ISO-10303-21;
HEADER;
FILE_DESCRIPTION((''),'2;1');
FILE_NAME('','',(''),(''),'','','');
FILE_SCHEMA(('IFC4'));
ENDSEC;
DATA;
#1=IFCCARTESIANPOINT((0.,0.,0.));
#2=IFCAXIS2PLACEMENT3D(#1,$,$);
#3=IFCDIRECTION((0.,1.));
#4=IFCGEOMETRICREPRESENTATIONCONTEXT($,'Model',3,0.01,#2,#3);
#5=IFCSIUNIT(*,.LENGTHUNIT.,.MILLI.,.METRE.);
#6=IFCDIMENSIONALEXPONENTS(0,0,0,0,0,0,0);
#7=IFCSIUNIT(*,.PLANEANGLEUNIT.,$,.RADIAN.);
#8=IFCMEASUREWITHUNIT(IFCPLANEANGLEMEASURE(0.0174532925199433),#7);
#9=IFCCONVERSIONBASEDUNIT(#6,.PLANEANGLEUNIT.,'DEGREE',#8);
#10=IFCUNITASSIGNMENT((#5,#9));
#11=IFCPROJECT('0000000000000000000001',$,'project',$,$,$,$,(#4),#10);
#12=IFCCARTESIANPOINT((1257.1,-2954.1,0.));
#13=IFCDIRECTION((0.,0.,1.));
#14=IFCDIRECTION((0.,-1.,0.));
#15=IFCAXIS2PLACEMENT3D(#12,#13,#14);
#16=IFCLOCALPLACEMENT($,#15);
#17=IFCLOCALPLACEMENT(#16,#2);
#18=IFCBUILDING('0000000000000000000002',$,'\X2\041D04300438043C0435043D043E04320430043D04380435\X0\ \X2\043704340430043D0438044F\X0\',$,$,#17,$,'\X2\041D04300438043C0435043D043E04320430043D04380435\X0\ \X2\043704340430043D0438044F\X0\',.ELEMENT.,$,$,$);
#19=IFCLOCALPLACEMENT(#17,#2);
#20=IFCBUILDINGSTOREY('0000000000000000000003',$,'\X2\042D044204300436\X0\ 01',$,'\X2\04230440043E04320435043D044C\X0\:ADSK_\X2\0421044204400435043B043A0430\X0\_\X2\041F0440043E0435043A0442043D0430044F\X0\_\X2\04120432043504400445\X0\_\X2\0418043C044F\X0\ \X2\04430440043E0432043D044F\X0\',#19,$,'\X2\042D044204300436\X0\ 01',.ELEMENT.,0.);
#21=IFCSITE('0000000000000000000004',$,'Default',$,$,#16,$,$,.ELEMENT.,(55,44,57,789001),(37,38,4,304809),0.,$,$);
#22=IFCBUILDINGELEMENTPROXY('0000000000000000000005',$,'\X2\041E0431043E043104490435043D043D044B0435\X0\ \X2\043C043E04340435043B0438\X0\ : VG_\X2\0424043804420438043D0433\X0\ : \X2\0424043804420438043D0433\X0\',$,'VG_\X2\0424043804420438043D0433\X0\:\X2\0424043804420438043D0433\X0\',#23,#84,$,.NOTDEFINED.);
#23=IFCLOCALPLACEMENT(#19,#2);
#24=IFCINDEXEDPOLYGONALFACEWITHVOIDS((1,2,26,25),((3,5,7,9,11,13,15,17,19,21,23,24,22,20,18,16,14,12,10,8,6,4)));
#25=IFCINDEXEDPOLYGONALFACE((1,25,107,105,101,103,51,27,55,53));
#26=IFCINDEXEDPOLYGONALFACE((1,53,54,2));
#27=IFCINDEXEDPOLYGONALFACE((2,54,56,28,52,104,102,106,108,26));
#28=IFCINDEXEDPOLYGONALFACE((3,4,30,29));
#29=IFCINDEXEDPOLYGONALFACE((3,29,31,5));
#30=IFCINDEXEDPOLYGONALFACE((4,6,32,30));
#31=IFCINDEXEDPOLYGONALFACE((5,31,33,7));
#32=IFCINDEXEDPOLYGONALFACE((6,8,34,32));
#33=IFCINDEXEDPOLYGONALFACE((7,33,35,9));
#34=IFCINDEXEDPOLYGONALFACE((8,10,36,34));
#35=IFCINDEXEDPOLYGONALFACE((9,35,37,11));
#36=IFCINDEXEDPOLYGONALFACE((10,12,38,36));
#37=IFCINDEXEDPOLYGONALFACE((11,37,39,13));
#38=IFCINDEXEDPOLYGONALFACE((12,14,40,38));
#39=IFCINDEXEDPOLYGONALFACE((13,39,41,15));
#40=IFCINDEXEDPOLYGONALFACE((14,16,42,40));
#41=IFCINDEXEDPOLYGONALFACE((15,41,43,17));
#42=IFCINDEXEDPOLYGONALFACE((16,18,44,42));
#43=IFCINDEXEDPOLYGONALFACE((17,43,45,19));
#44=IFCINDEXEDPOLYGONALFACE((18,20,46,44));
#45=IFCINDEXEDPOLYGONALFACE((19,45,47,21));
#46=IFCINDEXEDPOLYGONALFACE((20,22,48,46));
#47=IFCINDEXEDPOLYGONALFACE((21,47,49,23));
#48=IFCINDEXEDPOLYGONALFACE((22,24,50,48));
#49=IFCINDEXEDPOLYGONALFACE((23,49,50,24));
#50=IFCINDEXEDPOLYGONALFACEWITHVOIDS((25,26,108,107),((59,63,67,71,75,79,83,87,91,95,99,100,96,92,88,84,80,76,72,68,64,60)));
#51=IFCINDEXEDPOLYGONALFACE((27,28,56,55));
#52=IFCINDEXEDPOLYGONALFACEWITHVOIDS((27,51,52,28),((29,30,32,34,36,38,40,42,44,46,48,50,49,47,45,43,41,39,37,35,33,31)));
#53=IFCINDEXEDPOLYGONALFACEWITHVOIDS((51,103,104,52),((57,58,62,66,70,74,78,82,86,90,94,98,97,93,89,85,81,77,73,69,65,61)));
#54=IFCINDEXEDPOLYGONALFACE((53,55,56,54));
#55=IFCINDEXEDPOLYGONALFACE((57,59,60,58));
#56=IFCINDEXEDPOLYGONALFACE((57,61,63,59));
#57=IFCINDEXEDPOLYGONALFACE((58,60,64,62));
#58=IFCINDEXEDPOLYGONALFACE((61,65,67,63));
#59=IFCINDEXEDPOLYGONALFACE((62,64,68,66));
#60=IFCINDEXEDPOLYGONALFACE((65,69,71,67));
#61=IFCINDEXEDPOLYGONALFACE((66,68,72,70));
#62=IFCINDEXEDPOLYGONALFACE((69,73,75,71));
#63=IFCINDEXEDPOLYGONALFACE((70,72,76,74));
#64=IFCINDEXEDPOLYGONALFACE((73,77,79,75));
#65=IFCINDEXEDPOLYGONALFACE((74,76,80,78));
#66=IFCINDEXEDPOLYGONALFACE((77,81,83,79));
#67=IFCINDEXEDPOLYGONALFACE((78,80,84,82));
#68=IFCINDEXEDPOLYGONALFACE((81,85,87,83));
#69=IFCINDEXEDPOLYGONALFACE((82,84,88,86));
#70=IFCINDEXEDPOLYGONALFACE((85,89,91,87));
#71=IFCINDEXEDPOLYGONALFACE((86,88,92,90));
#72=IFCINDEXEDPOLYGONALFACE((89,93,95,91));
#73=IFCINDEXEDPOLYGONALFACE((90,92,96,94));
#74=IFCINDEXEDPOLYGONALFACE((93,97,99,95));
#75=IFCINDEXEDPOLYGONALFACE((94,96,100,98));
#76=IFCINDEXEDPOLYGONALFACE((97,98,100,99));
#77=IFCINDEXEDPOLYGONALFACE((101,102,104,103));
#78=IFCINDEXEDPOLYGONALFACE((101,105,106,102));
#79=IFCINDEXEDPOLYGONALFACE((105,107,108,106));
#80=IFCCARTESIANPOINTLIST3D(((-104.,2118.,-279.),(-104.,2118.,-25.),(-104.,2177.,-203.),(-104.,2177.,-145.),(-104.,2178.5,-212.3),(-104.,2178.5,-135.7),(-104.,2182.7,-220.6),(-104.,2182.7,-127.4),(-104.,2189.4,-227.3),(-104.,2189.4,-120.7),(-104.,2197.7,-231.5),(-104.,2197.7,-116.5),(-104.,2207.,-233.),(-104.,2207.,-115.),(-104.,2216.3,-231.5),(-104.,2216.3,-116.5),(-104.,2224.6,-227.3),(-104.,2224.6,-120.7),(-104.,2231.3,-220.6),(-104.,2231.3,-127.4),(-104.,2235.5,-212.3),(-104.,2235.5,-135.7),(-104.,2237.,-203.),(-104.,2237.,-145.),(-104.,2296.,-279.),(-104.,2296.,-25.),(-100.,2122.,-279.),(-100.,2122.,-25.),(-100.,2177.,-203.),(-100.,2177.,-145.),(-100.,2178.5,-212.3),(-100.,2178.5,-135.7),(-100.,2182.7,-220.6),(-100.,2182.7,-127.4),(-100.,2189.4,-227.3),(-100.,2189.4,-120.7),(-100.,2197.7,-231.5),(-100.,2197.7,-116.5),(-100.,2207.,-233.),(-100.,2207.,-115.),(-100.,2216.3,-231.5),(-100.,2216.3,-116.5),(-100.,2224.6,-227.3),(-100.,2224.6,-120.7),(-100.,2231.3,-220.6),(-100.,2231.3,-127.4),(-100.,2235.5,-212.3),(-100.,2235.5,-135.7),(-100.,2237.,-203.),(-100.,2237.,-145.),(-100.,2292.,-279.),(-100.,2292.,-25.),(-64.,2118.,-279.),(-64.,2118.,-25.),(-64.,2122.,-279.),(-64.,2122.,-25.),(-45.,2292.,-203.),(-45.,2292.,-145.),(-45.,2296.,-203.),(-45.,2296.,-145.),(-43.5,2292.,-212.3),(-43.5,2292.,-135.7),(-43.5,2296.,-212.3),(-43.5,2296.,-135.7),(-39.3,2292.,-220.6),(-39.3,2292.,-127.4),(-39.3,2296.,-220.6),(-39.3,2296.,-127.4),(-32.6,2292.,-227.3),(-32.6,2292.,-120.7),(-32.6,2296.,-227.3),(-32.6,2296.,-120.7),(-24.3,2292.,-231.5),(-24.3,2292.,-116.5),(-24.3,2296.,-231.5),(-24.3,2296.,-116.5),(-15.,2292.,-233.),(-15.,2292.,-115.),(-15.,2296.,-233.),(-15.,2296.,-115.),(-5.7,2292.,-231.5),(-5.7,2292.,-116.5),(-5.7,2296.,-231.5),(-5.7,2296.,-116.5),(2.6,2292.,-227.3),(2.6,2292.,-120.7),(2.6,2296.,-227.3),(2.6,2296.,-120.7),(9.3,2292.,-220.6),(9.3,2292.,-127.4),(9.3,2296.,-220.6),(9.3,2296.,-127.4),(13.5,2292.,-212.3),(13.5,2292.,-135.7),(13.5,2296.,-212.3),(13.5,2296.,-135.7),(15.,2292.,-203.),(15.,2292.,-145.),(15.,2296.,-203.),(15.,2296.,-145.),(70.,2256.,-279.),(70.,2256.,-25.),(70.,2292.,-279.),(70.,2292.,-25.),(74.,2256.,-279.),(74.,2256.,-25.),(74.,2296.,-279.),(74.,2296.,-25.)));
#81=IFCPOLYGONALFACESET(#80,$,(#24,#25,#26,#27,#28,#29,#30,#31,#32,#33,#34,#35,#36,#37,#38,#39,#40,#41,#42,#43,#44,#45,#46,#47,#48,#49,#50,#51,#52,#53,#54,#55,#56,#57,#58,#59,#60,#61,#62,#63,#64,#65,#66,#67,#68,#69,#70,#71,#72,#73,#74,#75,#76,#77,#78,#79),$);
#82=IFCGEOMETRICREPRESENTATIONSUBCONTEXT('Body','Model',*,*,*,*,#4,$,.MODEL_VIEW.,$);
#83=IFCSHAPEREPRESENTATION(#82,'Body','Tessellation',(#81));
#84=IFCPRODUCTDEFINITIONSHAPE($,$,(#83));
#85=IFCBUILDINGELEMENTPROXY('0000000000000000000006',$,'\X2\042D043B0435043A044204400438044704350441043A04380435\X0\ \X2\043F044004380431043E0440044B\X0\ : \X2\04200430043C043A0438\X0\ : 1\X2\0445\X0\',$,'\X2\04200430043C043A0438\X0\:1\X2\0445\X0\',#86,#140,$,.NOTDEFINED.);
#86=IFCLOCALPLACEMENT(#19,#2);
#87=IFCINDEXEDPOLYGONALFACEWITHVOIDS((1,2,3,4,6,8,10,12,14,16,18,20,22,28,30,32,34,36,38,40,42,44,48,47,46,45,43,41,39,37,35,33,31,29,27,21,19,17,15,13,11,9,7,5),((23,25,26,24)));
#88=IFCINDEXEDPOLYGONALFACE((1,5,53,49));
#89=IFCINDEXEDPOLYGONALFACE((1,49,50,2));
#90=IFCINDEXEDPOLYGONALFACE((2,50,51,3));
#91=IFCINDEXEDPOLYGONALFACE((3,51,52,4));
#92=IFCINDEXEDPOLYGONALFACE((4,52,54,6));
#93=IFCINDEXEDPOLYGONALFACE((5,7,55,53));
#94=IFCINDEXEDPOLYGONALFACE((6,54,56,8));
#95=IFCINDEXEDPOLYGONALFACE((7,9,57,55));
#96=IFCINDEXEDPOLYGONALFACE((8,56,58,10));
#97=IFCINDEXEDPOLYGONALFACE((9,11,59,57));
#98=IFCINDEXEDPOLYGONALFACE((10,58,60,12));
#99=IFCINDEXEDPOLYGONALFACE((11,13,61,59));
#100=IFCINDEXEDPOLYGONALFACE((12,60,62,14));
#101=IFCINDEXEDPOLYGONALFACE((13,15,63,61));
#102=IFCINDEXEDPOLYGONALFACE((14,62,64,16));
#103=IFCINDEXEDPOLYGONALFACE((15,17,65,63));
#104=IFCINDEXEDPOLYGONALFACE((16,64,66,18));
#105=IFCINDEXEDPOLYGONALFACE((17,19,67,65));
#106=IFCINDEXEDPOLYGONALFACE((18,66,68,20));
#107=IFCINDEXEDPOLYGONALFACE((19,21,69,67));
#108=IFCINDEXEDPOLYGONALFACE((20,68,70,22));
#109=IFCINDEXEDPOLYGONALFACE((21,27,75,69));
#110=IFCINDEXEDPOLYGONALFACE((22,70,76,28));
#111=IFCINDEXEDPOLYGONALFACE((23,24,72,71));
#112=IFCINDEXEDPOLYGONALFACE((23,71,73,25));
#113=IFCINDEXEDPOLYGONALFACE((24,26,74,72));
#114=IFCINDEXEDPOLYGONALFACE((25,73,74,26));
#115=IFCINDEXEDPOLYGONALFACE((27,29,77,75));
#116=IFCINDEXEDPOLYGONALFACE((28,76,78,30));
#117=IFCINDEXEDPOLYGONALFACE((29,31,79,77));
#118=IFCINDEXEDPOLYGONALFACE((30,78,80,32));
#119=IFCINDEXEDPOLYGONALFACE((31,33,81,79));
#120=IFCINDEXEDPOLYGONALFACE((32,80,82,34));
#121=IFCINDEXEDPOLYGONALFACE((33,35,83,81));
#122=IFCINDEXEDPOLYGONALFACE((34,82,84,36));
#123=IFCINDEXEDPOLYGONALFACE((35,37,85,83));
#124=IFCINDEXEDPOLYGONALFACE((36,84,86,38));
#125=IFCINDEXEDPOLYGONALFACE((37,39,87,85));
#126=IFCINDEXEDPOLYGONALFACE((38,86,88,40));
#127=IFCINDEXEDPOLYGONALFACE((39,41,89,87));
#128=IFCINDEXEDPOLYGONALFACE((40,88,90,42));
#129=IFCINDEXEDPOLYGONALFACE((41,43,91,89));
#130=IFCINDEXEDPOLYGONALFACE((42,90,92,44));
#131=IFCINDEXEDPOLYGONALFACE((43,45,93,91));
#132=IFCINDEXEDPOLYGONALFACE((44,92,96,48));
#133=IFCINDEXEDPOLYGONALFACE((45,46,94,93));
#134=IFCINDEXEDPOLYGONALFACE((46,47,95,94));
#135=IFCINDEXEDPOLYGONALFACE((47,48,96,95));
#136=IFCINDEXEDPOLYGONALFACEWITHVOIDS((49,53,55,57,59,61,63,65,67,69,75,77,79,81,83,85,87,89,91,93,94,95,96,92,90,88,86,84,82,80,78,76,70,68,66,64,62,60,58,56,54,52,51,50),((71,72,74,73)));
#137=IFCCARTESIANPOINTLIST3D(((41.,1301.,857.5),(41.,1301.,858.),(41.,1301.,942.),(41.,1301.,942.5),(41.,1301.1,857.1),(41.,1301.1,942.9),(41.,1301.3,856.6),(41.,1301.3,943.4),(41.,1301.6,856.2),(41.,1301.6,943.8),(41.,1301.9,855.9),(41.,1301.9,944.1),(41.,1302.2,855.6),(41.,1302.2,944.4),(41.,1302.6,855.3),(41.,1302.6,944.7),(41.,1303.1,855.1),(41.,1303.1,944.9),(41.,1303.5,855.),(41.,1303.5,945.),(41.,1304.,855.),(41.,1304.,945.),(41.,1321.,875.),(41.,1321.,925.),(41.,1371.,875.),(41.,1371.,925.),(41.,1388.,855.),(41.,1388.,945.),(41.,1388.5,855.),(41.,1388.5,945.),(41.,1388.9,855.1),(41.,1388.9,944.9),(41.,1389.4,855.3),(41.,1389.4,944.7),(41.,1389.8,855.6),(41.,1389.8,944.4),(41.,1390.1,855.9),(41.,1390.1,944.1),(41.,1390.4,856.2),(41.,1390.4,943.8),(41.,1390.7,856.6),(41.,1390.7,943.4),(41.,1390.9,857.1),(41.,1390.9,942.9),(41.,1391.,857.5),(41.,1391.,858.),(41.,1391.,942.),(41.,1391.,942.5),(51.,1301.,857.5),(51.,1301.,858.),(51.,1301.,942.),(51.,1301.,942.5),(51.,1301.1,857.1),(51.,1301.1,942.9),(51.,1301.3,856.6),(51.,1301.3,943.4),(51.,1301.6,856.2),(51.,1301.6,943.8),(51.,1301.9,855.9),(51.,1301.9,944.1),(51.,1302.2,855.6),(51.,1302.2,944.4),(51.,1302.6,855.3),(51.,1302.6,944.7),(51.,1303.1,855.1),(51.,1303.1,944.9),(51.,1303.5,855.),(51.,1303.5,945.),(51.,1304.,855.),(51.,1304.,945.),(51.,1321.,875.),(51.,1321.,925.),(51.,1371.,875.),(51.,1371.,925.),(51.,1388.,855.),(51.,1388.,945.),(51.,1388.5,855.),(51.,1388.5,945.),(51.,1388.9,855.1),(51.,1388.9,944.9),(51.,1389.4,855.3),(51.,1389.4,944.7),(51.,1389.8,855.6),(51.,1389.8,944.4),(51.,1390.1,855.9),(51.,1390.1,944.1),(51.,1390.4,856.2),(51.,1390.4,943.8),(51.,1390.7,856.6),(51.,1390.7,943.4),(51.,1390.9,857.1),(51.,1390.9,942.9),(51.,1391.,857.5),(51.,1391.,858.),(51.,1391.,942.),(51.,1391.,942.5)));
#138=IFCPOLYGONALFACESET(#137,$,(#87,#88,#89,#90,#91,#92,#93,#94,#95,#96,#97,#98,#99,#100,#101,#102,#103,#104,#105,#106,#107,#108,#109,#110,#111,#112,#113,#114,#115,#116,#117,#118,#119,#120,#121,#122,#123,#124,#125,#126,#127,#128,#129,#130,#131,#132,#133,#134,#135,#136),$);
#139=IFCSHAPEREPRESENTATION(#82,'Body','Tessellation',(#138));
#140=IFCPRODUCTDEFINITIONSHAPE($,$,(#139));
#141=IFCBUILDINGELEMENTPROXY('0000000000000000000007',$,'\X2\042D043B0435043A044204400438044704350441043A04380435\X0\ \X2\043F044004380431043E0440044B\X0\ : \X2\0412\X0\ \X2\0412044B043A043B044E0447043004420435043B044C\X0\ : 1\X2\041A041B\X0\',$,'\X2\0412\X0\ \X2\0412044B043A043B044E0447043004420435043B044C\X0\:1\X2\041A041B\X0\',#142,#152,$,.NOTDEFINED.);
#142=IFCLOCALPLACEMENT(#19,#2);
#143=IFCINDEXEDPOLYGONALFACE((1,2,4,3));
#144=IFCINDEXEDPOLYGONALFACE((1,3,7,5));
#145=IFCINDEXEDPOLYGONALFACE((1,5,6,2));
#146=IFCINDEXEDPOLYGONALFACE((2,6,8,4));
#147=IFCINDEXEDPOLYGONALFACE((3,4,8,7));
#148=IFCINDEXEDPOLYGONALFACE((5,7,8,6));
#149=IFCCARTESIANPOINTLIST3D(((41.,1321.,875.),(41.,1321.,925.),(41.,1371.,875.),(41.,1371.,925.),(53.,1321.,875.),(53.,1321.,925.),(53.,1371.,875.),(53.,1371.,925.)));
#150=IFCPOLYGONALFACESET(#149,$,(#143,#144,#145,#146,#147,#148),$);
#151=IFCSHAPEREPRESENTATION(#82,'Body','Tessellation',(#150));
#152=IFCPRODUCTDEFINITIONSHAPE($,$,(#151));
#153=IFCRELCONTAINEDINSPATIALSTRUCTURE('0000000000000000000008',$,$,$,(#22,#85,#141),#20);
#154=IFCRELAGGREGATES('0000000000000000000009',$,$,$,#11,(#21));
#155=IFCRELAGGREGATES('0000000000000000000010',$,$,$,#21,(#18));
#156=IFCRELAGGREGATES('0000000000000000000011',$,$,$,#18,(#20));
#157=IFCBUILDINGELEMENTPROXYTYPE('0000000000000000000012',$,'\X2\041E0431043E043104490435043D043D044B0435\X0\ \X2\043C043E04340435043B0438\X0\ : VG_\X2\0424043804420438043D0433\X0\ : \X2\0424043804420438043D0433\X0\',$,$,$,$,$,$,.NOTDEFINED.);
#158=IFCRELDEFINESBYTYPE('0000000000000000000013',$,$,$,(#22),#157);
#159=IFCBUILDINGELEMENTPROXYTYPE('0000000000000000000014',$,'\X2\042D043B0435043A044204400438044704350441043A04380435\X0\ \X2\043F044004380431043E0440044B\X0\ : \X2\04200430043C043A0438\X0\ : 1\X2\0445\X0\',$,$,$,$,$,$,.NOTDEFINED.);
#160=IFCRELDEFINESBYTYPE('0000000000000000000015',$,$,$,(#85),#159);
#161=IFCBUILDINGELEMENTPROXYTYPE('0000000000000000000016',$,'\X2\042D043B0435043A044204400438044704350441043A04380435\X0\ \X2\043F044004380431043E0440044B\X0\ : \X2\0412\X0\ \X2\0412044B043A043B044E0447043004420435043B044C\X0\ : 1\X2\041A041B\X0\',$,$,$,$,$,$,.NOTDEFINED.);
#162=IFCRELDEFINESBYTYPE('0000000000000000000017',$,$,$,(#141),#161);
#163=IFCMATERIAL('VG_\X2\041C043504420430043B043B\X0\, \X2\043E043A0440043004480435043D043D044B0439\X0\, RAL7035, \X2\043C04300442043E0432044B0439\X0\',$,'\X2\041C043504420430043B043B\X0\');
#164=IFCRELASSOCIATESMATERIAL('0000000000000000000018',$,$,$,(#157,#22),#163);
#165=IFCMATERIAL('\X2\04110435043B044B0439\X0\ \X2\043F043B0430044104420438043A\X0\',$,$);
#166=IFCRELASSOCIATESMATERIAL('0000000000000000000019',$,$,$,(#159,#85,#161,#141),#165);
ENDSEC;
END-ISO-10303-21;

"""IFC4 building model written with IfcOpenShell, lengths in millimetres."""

from ifc_helpers import new_model, entity, si_unit, converted_unit, direction, frame, origin, place, context, subcontext, project, spatial, indexed_curve, outline, extrude, source, transform, mapped, material, type_object, type_shapes, element, save


model = new_model("IFC4")

# Units and contexts
model_context = context("Model", 3, precision=0.01, world=origin(), true_north=direction((0.0, 1.0)))
body_context = subcontext(model_context, "Body", "Model", "MODEL_VIEW")
ifc_project = project(units=[si_unit("LENGTHUNIT", "METRE", prefix="MILLI"), converted_unit("PLANEANGLEUNIT", "DEGREE", entity("IfcPlaneAngleMeasure", 0.0174532925199433), si_unit("PLANEANGLEUNIT", "RADIAN"), dimensions=[0, 0, 0, 0, 0, 0, 0])], contexts=[model_context])

# Site, building, storey
site_placement = place(None, frame((1257.1, -2954.1, 0.0), z_axis=(0.0, 0.0, 1.0), x_axis=(0.0, -1.0, 0.0)))
site = spatial("IfcSite", under=ifc_project, at=site_placement, Name="Default", CompositionType="ELEMENT", RefLatitude=(55, 44, 57, 789001), RefLongitude=(37, 38, 4, 304809), RefElevation=0.0)
building_placement = place(site_placement, origin())
building = spatial("IfcBuilding", under=site, at=building_placement, Name="Наименование здания", LongName="Наименование здания", CompositionType="ELEMENT")
storey_placement = place(building_placement, origin())
storey = spatial("IfcBuildingStorey", under=building, at=storey_placement, Name="Этаж 01", ObjectType="Уровень:ADSK_Стрелка_Проектная_Вверх_Имя уровня", LongName="Этаж 01", CompositionType="ELEMENT", Elevation=0.0)

# Building element proxy, openings
ifc_material_1 = material(Name="VG_Металл, окрашенный, RAL7035, матовый", Category="Металл")
building_element_proxy_type_1 = type_object("IfcBuildingElementProxyType", Name="Обобщенные модели : VG_Фитинг : Фитинг", PredefinedType="NOTDEFINED", material=ifc_material_1)
shared_shape_1 = source(origin(), body_context, "Body", "SweptSolid", [
    extrude(outline(indexed_curve([(-79.2, -79.2), (98.8, -79.2), (98.8, -39.2), (94.8, -39.2), (94.8, -75.2), (-75.2, -75.2), (-75.2, 94.8), (-39.2, 94.8), (-39.2, 98.8), (-79.2, 98.8), (-79.2, -79.2)], self_intersect=False)), frame((-9.8, -9.8, -279.0)), (0.0, 0.0, 1.0), 254.0),
])
type_shapes(building_element_proxy_type_1, [shared_shape_1])
proxy_1_placement = place(storey_placement, frame((-15.0, 2207.0, 0.0), z_axis=(0.0, 0.0, 1.0), x_axis=(0.0, -1.0, 0.0)))
proxy_1 = element("IfcBuildingElementProxy", 1, at=proxy_1_placement, inside=storey, type_object=building_element_proxy_type_1, material=ifc_material_1, Name="Обобщенные модели : VG_Фитинг : Фитинг", ObjectType="VG_Фитинг:Фитинг", PredefinedType="NOTDEFINED", context=body_context, shape_type="MappedRepresentation", body=[
    mapped(shared_shape_1, transform((0.0, 0.0, 0.0), scale=1.0)),
])
opening_1_placement = place(storey_placement, frame((-15.0, 2207.0, 0.0), z_axis=(0.0, 0.0, 1.0), x_axis=(-1.0, 0.0, 0.0)))
element("IfcOpeningElement", 2, at=opening_1_placement, cuts=proxy_1, PredefinedType="OPENING", context=body_context, shape_type="SweptSolid", body=[
    extrude(outline(indexed_curve([(30.0, 29.0), (28.5, 38.3), (24.3, 46.6), (17.6, 53.3), (9.3, 57.5), (0.0, 59.0), (-9.3, 57.5), (-17.6, 53.3), (-24.3, 46.6), (-28.5, 38.3), (-30.0, 29.0), (-30.0, -29.0), (-28.5, -38.3), (-24.3, -46.6), (-17.6, -53.3), (-9.3, -57.5), (0.0, -59.0), (9.3, -57.5), (17.6, -53.3), (24.3, -46.6), (28.5, -38.3), (30.0, -29.0), (30.0, 29.0)], self_intersect=False)), frame((0.0, -85.0, -174.0), z_axis=(0.0, -1.0, 0.0), x_axis=(1.0, 0.0, 0.0)), (0.0, 0.0, 1.0), 4.0),
])
opening_2_placement = place(storey_placement, frame((-15.0, 2207.0, 0.0), z_axis=(0.0, 0.0, 1.0), x_axis=(-1.0, 0.0, 0.0)))
element("IfcOpeningElement", 3, at=opening_2_placement, cuts=proxy_1, PredefinedType="OPENING", context=body_context, shape_type="SweptSolid", body=[
    extrude(outline(indexed_curve([(-30.0, -29.0), (-28.5, -38.3), (-24.3, -46.6), (-17.6, -53.3), (-9.3, -57.5), (0.0, -59.0), (9.3, -57.5), (17.6, -53.3), (24.3, -46.6), (28.5, -38.3), (30.0, -29.0), (30.0, 29.0), (28.5, 38.3), (24.3, 46.6), (17.6, 53.3), (9.3, 57.5), (0.0, 59.0), (-9.3, 57.5), (-17.6, 53.3), (-24.3, 46.6), (-28.5, 38.3), (-30.0, 29.0), (-30.0, -29.0)], self_intersect=False)), frame((89.0, 0.0, -174.0), z_axis=(-1.0, 0.0, 0.0), x_axis=(0.0, 1.0, 0.0)), (0.0, 0.0, 1.0), 4.0),
])

# Building element proxies
ifc_material_2 = material(Name="Белый пластик")
building_element_proxy_type_2 = type_object("IfcBuildingElementProxyType", Name="Электрические приборы : Рамки : 1х", PredefinedType="NOTDEFINED", material=ifc_material_2)
shared_shape_2 = source(origin(), body_context, "Body", "SweptSolid", [
    extrude(outline(indexed_curve([(-42.0, 45.0), (-42.5, 45.0), (-42.9, 44.9), (-43.4, 44.7), (-43.8, 44.4), (-44.1, 44.1), (-44.4, 43.8), (-44.7, 43.4), (-44.9, 42.9), (-45.0, 42.5), (-45.0, 42.0), (-45.0, -42.0), (-45.0, -42.5), (-44.9, -42.9), (-44.7, -43.4), (-44.4, -43.8), (-44.1, -44.1), (-43.8, -44.4), (-43.4, -44.7), (-42.9, -44.9), (-42.5, -45.0), (-42.0, -45.0), (42.0, -45.0), (42.5, -45.0), (42.9, -44.9), (43.4, -44.7), (43.8, -44.4), (44.1, -44.1), (44.4, -43.8), (44.7, -43.4), (44.9, -42.9), (45.0, -42.5), (45.0, -42.0), (45.0, 42.0), (45.0, 42.5), (44.9, 42.9), (44.7, 43.4), (44.4, 43.8), (44.1, 44.1), (43.8, 44.4), (43.4, 44.7), (42.9, 44.9), (42.5, 45.0), (42.0, 45.0), (-42.0, 45.0)], self_intersect=False), holes=[indexed_curve([(-25.0, 25.0), (25.0, 25.0), (25.0, -25.0), (-25.0, -25.0), (-25.0, 25.0)], self_intersect=False)]), origin(), (0.0, 0.0, 1.0), 10.0),
])
type_shapes(building_element_proxy_type_2, [shared_shape_2])
proxy_2_placement = place(storey_placement, frame((41.0, 1346.0, 900.0), z_axis=(1.0, 0.0, 0.0), x_axis=(0.0, 1.0, 0.0)))
element("IfcBuildingElementProxy", 4, at=proxy_2_placement, inside=storey, type_object=building_element_proxy_type_2, material=ifc_material_2, Name="Электрические приборы : Рамки : 1х", ObjectType="Рамки:1х", PredefinedType="NOTDEFINED", context=body_context, shape_type="MappedRepresentation", body=[
    mapped(shared_shape_2, transform((0.0, 0.0, 0.0), scale=1.0)),
])
building_element_proxy_type_3 = type_object("IfcBuildingElementProxyType", Name="Электрические приборы : В Выключатель : 1КЛ", PredefinedType="NOTDEFINED", material=ifc_material_2)
shared_shape_3 = source(origin(), body_context, "Body", "SweptSolid", [
    extrude(outline(indexed_curve([(-25.0, -25.0), (25.0, -25.0), (25.0, 25.0), (-25.0, 25.0), (-25.0, -25.0)], self_intersect=False)), frame((359.8, -712.5, 0.0), z_axis=(0.0, 0.0, 1.0), x_axis=(-1.0, 0.0, 0.0)), (0.0, 0.0, 1.0), 12.0),
])
type_shapes(building_element_proxy_type_3, [shared_shape_3])
proxy_3_placement = place(storey_placement, frame((41.0, 986.2, 1612.5), z_axis=(1.0, 0.0, 0.0), x_axis=(0.0, 1.0, 0.0)))
element("IfcBuildingElementProxy", 5, at=proxy_3_placement, inside=storey, type_object=building_element_proxy_type_3, material=ifc_material_2, Name="Электрические приборы : В Выключатель : 1КЛ", ObjectType="В Выключатель:1КЛ", PredefinedType="NOTDEFINED", context=body_context, shape_type="MappedRepresentation", body=[
    mapped(shared_shape_3, transform((0.0, 0.0, 0.0), scale=1.0)),
])

save(model, "model.ifc")
